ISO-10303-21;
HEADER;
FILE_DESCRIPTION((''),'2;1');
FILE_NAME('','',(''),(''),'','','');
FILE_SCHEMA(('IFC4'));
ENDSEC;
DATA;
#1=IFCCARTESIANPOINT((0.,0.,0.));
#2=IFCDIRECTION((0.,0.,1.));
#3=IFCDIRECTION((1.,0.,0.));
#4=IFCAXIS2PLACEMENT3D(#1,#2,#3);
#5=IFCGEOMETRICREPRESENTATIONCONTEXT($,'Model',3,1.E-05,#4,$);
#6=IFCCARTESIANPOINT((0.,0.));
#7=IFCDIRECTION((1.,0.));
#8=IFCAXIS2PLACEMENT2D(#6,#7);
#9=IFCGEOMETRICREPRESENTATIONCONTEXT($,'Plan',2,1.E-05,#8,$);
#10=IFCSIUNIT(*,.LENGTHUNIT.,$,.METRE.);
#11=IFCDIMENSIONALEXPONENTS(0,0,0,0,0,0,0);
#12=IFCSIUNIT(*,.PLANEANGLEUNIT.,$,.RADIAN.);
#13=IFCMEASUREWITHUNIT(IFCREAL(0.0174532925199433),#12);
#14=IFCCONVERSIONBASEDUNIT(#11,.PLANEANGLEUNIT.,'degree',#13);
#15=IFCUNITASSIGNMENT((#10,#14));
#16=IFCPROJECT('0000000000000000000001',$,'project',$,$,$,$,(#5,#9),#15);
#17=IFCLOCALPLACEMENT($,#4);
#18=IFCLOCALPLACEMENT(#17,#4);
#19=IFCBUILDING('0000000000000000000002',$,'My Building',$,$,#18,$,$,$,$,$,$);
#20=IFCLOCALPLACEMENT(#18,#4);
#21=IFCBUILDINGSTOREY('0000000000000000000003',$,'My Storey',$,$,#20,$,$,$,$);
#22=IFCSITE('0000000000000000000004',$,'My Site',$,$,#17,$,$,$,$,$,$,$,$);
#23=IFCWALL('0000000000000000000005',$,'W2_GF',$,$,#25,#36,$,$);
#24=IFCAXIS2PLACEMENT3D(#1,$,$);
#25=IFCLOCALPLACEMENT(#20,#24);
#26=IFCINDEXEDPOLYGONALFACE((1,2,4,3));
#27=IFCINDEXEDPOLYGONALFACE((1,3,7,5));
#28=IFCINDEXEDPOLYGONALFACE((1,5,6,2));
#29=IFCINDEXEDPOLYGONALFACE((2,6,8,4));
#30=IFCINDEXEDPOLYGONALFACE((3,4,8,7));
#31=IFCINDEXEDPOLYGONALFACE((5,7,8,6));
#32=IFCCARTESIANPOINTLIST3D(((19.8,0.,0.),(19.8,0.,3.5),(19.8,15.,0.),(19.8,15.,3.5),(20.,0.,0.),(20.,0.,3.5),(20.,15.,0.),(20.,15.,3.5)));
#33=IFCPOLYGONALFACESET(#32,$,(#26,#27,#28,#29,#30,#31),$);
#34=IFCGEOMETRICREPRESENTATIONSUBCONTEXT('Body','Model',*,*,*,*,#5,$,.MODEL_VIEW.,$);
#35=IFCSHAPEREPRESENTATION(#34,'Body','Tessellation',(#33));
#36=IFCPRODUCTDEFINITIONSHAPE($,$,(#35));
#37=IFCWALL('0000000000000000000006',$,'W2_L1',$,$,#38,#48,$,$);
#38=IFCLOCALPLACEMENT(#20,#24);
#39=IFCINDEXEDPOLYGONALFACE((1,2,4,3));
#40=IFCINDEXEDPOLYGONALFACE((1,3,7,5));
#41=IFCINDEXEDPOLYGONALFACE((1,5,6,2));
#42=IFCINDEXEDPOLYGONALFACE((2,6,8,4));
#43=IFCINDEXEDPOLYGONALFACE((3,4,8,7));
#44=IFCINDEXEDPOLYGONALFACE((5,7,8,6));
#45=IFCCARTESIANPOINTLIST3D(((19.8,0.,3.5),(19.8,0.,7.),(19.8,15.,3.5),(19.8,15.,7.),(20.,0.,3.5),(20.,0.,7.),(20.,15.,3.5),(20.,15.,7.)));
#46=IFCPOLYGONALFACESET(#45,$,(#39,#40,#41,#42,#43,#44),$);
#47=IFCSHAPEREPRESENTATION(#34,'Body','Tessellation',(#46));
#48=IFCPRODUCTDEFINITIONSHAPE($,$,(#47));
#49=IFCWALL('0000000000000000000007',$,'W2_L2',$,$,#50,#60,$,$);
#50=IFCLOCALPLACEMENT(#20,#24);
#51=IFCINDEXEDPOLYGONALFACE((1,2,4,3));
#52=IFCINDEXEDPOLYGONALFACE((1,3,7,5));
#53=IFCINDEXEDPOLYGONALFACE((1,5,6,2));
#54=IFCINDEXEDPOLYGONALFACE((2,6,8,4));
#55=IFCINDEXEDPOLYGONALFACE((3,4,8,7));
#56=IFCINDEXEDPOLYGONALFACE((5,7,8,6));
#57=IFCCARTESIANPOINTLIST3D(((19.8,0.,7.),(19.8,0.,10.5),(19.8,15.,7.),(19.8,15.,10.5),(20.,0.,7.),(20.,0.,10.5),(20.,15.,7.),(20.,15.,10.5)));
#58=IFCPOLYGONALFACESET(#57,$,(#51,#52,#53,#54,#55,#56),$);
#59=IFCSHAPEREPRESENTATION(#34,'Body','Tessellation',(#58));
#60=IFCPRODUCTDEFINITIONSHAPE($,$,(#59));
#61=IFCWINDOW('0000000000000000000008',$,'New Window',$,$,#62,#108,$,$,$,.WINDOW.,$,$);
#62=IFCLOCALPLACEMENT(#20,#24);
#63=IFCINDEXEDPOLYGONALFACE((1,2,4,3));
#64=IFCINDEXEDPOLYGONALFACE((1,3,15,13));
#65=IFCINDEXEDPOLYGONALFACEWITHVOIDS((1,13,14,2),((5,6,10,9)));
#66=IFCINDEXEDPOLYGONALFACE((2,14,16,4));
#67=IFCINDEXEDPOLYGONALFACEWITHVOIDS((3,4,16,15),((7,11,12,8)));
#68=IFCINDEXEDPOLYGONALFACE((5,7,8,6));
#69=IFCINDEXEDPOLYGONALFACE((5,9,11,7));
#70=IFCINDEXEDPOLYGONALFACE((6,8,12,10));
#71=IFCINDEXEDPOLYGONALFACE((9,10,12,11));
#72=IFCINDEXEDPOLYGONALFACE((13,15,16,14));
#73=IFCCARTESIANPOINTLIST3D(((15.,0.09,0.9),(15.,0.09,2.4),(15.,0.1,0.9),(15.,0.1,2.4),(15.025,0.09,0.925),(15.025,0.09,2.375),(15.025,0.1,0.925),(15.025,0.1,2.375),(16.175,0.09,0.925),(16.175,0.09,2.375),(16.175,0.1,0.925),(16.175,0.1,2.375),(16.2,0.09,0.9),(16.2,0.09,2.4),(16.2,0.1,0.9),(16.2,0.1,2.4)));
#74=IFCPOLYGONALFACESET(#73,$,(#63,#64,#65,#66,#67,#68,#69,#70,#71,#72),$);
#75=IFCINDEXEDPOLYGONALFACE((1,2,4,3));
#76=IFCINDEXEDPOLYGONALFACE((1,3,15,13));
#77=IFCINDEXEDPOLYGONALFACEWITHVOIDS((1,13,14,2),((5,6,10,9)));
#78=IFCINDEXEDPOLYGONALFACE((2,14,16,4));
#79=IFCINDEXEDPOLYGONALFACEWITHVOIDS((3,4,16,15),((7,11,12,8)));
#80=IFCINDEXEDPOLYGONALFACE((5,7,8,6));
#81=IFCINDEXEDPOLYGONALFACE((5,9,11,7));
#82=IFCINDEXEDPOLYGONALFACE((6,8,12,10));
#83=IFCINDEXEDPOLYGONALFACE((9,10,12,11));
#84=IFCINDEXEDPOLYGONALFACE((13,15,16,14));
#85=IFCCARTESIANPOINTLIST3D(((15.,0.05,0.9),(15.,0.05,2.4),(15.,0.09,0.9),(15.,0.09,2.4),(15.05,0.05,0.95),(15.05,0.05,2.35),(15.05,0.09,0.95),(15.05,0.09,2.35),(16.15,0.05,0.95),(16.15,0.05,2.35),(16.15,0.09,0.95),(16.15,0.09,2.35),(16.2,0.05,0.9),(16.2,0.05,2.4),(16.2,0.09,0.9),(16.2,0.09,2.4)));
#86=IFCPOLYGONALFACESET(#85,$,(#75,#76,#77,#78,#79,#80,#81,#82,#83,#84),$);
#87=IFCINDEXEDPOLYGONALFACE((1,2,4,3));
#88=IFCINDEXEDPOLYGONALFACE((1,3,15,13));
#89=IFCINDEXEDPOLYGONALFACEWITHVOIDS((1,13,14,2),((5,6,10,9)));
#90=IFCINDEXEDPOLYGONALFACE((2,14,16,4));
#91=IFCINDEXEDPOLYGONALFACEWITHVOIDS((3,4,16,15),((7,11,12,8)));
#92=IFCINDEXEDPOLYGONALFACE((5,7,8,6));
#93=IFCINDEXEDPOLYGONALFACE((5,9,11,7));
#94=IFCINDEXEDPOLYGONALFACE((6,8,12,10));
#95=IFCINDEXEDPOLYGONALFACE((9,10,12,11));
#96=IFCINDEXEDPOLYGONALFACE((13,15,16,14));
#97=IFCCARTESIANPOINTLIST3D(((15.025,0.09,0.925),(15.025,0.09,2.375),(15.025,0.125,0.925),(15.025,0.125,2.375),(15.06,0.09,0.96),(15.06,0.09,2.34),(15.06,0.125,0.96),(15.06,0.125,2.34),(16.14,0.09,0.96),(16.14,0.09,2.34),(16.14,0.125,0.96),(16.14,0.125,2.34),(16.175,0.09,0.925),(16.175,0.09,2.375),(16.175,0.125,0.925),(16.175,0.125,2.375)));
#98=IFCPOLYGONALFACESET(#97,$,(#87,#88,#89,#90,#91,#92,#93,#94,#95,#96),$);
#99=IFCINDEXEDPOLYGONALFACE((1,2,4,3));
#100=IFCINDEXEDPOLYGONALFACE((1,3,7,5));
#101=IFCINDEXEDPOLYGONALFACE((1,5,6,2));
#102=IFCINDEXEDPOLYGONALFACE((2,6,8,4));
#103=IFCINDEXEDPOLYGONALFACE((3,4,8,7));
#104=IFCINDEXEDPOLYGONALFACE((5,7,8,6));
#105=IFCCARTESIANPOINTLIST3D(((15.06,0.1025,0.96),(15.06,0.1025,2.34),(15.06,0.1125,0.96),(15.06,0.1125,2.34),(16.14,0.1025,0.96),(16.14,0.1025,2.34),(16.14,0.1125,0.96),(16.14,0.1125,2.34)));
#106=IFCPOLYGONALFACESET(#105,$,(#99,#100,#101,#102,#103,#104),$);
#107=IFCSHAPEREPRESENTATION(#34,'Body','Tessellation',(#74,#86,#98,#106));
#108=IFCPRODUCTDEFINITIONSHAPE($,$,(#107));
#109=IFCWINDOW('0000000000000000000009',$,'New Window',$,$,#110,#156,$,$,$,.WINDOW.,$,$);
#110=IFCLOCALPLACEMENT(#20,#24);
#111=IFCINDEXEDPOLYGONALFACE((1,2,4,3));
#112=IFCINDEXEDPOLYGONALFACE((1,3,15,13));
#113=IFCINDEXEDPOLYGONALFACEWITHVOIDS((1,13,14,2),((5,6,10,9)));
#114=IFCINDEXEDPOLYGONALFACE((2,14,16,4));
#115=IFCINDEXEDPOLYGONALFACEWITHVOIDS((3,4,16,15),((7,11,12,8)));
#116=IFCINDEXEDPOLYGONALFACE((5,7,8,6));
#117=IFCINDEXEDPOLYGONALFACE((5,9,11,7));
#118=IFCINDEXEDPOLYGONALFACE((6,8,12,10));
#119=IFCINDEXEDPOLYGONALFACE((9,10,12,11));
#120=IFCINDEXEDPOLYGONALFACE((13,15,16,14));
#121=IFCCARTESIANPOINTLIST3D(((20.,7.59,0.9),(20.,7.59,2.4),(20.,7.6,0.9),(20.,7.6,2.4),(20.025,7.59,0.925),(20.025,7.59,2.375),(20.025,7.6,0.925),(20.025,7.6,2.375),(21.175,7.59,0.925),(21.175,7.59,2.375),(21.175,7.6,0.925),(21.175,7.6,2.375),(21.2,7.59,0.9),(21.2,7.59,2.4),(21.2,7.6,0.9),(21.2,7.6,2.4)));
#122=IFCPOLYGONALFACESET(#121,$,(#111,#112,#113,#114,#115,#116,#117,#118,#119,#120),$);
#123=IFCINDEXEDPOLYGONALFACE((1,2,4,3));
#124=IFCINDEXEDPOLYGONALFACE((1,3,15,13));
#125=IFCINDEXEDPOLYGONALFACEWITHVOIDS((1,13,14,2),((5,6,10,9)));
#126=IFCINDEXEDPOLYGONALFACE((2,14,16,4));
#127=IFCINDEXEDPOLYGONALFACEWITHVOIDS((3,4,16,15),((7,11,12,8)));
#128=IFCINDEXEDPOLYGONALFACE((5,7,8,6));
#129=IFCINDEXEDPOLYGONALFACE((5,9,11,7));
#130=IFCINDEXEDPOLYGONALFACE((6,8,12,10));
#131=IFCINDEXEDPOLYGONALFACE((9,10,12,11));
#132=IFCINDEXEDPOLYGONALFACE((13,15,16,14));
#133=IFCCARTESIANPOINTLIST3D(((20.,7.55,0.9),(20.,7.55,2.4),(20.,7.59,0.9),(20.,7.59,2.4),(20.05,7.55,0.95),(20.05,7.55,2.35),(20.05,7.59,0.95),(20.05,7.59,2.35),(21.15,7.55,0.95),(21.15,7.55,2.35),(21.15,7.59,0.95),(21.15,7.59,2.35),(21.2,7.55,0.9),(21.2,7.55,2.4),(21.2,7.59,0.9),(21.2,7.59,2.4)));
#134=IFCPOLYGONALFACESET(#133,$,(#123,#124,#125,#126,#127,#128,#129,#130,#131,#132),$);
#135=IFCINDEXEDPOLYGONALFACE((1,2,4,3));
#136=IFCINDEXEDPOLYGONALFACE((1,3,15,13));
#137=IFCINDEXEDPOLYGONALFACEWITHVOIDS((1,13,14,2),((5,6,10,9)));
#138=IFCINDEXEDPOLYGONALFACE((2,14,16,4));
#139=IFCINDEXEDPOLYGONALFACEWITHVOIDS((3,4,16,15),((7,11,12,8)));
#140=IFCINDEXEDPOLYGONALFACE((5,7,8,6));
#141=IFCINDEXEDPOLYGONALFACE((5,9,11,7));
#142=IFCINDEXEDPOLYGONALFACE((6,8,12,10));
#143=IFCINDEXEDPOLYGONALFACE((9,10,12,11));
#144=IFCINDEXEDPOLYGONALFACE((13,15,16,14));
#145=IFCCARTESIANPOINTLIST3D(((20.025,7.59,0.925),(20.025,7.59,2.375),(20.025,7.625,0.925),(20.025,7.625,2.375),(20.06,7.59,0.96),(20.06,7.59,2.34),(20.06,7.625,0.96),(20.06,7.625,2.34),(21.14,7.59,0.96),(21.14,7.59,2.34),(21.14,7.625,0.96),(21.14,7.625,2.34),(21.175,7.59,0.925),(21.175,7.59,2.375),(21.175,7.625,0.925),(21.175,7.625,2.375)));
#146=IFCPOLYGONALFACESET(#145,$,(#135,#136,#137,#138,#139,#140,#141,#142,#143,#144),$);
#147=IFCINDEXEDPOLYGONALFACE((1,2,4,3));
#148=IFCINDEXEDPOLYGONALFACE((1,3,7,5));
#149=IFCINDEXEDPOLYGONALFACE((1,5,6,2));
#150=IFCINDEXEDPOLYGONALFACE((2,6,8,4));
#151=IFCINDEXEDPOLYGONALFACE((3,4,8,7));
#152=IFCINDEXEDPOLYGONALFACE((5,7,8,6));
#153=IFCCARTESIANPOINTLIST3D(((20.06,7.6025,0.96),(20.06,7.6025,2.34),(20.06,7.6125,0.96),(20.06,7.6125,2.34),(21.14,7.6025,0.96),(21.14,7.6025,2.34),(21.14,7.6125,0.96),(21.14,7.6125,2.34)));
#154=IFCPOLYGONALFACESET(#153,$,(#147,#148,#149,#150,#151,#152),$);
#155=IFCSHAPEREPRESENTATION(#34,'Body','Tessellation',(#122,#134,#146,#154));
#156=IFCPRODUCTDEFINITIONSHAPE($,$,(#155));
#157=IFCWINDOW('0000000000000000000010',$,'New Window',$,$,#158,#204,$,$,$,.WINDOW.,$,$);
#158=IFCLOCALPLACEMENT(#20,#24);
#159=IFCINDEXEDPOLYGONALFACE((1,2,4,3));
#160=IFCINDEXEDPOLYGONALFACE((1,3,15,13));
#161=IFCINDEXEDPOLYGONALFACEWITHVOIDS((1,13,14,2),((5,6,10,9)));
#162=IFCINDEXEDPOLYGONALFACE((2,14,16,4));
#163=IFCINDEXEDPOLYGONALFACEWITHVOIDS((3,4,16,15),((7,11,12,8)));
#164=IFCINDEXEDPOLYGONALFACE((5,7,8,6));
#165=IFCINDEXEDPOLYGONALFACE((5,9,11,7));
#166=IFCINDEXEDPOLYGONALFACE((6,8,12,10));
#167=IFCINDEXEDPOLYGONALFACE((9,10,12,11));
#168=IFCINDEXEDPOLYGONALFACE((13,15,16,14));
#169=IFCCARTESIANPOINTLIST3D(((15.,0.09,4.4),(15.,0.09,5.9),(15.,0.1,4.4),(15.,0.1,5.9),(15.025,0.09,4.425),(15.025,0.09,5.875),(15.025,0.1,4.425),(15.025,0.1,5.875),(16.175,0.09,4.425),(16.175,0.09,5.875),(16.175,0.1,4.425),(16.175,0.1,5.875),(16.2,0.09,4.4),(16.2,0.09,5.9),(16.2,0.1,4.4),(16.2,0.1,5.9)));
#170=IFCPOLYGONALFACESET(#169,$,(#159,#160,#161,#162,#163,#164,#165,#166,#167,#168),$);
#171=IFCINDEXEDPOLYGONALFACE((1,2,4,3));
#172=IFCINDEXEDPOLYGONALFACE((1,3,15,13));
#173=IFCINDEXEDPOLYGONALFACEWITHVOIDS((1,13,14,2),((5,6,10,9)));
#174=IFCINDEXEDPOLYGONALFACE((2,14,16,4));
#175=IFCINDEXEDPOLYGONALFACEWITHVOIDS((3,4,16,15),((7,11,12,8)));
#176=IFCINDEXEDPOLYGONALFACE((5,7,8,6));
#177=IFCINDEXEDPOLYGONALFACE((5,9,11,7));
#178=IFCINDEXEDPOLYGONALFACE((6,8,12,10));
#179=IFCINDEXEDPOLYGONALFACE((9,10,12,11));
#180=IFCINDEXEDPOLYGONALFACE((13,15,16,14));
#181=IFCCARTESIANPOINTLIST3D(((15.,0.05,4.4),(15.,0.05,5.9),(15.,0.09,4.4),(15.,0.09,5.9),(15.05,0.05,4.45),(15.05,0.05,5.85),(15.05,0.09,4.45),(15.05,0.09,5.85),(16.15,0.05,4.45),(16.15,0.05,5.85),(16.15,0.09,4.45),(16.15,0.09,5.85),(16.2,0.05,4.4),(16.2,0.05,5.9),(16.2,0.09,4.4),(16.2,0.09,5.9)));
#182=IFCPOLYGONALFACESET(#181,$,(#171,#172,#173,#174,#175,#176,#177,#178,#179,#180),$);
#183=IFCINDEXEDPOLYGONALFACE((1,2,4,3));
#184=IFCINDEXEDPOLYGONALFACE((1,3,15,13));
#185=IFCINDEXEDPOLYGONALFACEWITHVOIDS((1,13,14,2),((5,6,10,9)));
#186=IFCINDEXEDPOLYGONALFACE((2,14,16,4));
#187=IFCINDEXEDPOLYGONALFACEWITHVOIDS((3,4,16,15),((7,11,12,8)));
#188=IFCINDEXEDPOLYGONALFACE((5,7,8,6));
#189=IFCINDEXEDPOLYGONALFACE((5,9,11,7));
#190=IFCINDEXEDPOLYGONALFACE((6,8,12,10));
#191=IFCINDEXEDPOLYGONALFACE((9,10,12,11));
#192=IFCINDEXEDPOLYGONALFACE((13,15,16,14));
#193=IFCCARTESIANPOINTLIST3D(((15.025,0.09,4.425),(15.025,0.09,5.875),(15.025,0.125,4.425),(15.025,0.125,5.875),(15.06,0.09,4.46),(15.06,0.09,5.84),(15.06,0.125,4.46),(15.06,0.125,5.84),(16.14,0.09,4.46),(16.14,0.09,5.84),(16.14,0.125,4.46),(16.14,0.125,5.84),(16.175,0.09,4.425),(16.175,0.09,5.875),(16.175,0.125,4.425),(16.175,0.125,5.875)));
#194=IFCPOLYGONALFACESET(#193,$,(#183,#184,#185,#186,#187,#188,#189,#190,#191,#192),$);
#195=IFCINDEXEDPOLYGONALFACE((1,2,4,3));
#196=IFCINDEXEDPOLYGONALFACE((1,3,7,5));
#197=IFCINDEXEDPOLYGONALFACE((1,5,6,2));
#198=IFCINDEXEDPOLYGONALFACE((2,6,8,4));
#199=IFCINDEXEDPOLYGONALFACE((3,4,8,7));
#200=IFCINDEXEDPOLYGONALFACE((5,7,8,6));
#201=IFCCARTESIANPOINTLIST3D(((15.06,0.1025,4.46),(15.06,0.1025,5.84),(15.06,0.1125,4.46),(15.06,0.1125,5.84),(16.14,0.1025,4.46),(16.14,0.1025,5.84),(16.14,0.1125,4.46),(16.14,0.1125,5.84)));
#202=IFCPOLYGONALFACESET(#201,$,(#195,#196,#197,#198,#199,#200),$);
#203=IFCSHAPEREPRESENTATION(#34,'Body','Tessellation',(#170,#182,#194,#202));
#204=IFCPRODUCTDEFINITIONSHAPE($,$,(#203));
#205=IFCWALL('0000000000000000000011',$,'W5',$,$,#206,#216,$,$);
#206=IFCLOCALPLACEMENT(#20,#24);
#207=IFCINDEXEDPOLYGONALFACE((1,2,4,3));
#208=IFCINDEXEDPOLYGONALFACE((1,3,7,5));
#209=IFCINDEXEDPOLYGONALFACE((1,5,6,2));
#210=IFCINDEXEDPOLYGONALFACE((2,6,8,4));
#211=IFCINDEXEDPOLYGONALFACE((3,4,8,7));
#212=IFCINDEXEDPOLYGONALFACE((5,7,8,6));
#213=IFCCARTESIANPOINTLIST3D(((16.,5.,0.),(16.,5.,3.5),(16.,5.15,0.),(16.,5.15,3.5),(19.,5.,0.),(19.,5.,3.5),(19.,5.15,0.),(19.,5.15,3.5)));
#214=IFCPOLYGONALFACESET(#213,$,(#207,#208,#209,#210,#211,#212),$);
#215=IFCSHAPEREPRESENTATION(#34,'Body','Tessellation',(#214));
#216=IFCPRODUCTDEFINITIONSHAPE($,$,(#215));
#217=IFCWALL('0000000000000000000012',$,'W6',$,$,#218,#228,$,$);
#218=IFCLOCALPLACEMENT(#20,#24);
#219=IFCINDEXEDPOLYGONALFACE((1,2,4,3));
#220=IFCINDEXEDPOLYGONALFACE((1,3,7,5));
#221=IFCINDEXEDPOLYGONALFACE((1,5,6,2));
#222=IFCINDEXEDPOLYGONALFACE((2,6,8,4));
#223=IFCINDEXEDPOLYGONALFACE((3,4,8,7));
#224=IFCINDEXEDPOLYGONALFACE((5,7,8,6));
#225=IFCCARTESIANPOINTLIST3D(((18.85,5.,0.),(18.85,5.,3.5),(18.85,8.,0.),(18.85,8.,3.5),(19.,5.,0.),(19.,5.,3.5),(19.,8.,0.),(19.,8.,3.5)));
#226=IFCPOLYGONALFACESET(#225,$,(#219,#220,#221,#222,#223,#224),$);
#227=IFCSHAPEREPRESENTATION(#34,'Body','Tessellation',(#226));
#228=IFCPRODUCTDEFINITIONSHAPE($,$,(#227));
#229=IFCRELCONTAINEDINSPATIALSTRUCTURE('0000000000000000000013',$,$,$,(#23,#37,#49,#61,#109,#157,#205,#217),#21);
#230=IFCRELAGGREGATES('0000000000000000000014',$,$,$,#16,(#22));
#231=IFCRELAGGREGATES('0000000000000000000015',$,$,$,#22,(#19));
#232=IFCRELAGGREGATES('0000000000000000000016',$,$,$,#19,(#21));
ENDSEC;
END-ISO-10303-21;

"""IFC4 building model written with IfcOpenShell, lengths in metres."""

from ifc_helpers import new_model, entity, si_unit, converted_unit, frame, origin_with_axes, origin_2d_with_axis, place, context, subcontext, project, spatial, line, indexed_curve, outline, extrude, element, save


model = new_model("IFC4")

# Units and contexts
model_context = context("Model", 3, precision=1e-05, world=origin_with_axes())
plan_context = context("Plan", 2, precision=1e-05, world=origin_2d_with_axis())
body_context = subcontext(model_context, "Body", "Model", "MODEL_VIEW")
ifc_project = project(units=[si_unit("LENGTHUNIT", "METRE"), converted_unit("PLANEANGLEUNIT", "degree", entity("IfcReal", 0.0174532925199433), si_unit("PLANEANGLEUNIT", "RADIAN"), dimensions=[0, 0, 0, 0, 0, 0, 0])], contexts=[model_context, plan_context])

# Site, building, storey
site_placement = place(None, origin_with_axes())
site = spatial("IfcSite", under=ifc_project, at=site_placement, Name="My Site")
building_placement = place(site_placement, origin_with_axes())
building = spatial("IfcBuilding", under=site, at=building_placement, Name="My Building")
storey_placement = place(building_placement, origin_with_axes())
storey = spatial("IfcBuildingStorey", under=building, at=storey_placement, Name="My Storey")

# Walls
for number, where, z_axis, x_axis, name in (
    (1, (20.0, 0.0, 0.0), (0.0, 0.0, 1.0), (0.0, 1.0, 0.0), "W2_GF"),
    (2, (20.0, 0.0, 3.5), (0.0, 0.0, 1.0), (0.0, 1.0, 0.0), "W2_L1"),
    (3, (20.0, 0.0, 7.0), (0.0, 0.0, 1.0), (0.0, 1.0, 0.0), "W2_L2"),
):
    element("IfcWall", number, at=place(storey_placement, frame(where, z_axis=z_axis, x_axis=x_axis)), inside=storey, Name=name, context=body_context, shape_type="SweptSolid", body=[
        extrude(outline(indexed_curve([(0.0, 0.0), (0.0, 0.2), (15.0, 0.2), (15.0, 0.0), (0.0, 0.0)], self_intersect=False)), origin_with_axes(), (0.0, 0.0, 1.0), 3.5),
    ])

# Windows
for number, where, z_axis, x_axis, name in (
    (4, (15.0, 0.0, 0.9), (0.0, 0.0, 1.0), (1.0, 0.0, 0.0), "New Window"),
    (5, (20.0, 7.5, 0.9), (0.0, 0.0, 1.0), (1.0, 0.0, 0.0), "New Window"),
    (6, (15.0, 0.0, 4.4), (0.0, 0.0, 1.0), (1.0, 0.0, 0.0), "New Window"),
):
    element("IfcWindow", number, at=place(storey_placement, frame(where, z_axis=z_axis, x_axis=x_axis)), inside=storey, Name=name, PredefinedType="WINDOW", context=body_context, shape_type="SweptSolid", body=[
        extrude(outline(indexed_curve([(0.0, 0.0), (1.2, 0.0), (1.2, 1.5), (0.0, 1.5)], segments=[line(1, 2, 3, 4, 1)]), holes=[indexed_curve([(0.025, 0.025), (1.175, 0.025), (1.175, 1.475), (0.025, 1.475)], segments=[line(1, 2, 3, 4, 1)])]), frame((0.0, 0.09, 0.0), z_axis=(0.0, -1.0, 0.0), x_axis=(1.0, 0.0, 0.0)), (0.0, 0.0, -1.0), 0.01),
        extrude(outline(indexed_curve([(0.0, 0.0), (1.2, 0.0), (1.2, 1.5), (0.0, 1.5)], segments=[line(1, 2, 3, 4, 1)]), holes=[indexed_curve([(0.05, 0.05), (1.15, 0.05), (1.15, 1.45), (0.05, 1.45)], segments=[line(1, 2, 3, 4, 1)])]), frame((0.0, 0.05, 0.0), z_axis=(0.0, -1.0, 0.0), x_axis=(1.0, 0.0, 0.0)), (0.0, 0.0, -1.0), 0.04),
        extrude(outline(indexed_curve([(0.0, 0.0), (1.15, 0.0), (1.15, 1.45), (0.0, 1.45)], segments=[line(1, 2, 3, 4, 1)]), holes=[indexed_curve([(0.035, 0.035), (1.115, 0.035), (1.115, 1.415), (0.035, 1.415)], segments=[line(1, 2, 3, 4, 1)])]), frame((0.025, 0.09, 0.025), z_axis=(0.0, -1.0, 0.0), x_axis=(1.0, 0.0, 0.0)), (0.0, 0.0, -1.0), 0.035),
        extrude(outline(indexed_curve([(0.035, 0.035), (1.115, 0.035), (1.115, 1.415), (0.035, 1.415)], segments=[line(1, 2, 3, 4, 1)])), frame((0.025, 0.1025, 0.025), z_axis=(0.0, -1.0, 0.0), x_axis=(1.0, 0.0, 0.0)), (0.0, 0.0, -1.0), 0.01),
    ])

# Walls
for number, where, z_axis, x_axis, name in (
    (7, (16.0, 5.0, 0.0), (0.0, 0.0, 1.0), (1.0, 0.0, 0.0), "W5"),
    (8, (19.0, 5.0, 0.0), (0.0, 0.0, 1.0), (0.0, 1.0, 0.0), "W6"),
):
    element("IfcWall", number, at=place(storey_placement, frame(where, z_axis=z_axis, x_axis=x_axis)), inside=storey, Name=name, context=body_context, shape_type="SweptSolid", body=[
        extrude(outline(indexed_curve([(0.0, 0.0), (0.0, 0.15), (3.0, 0.15), (3.0, 0.0), (0.0, 0.0)], self_intersect=False)), origin_with_axes(), (0.0, 0.0, 1.0), 3.5),
    ])

save(model, "model.ifc")
